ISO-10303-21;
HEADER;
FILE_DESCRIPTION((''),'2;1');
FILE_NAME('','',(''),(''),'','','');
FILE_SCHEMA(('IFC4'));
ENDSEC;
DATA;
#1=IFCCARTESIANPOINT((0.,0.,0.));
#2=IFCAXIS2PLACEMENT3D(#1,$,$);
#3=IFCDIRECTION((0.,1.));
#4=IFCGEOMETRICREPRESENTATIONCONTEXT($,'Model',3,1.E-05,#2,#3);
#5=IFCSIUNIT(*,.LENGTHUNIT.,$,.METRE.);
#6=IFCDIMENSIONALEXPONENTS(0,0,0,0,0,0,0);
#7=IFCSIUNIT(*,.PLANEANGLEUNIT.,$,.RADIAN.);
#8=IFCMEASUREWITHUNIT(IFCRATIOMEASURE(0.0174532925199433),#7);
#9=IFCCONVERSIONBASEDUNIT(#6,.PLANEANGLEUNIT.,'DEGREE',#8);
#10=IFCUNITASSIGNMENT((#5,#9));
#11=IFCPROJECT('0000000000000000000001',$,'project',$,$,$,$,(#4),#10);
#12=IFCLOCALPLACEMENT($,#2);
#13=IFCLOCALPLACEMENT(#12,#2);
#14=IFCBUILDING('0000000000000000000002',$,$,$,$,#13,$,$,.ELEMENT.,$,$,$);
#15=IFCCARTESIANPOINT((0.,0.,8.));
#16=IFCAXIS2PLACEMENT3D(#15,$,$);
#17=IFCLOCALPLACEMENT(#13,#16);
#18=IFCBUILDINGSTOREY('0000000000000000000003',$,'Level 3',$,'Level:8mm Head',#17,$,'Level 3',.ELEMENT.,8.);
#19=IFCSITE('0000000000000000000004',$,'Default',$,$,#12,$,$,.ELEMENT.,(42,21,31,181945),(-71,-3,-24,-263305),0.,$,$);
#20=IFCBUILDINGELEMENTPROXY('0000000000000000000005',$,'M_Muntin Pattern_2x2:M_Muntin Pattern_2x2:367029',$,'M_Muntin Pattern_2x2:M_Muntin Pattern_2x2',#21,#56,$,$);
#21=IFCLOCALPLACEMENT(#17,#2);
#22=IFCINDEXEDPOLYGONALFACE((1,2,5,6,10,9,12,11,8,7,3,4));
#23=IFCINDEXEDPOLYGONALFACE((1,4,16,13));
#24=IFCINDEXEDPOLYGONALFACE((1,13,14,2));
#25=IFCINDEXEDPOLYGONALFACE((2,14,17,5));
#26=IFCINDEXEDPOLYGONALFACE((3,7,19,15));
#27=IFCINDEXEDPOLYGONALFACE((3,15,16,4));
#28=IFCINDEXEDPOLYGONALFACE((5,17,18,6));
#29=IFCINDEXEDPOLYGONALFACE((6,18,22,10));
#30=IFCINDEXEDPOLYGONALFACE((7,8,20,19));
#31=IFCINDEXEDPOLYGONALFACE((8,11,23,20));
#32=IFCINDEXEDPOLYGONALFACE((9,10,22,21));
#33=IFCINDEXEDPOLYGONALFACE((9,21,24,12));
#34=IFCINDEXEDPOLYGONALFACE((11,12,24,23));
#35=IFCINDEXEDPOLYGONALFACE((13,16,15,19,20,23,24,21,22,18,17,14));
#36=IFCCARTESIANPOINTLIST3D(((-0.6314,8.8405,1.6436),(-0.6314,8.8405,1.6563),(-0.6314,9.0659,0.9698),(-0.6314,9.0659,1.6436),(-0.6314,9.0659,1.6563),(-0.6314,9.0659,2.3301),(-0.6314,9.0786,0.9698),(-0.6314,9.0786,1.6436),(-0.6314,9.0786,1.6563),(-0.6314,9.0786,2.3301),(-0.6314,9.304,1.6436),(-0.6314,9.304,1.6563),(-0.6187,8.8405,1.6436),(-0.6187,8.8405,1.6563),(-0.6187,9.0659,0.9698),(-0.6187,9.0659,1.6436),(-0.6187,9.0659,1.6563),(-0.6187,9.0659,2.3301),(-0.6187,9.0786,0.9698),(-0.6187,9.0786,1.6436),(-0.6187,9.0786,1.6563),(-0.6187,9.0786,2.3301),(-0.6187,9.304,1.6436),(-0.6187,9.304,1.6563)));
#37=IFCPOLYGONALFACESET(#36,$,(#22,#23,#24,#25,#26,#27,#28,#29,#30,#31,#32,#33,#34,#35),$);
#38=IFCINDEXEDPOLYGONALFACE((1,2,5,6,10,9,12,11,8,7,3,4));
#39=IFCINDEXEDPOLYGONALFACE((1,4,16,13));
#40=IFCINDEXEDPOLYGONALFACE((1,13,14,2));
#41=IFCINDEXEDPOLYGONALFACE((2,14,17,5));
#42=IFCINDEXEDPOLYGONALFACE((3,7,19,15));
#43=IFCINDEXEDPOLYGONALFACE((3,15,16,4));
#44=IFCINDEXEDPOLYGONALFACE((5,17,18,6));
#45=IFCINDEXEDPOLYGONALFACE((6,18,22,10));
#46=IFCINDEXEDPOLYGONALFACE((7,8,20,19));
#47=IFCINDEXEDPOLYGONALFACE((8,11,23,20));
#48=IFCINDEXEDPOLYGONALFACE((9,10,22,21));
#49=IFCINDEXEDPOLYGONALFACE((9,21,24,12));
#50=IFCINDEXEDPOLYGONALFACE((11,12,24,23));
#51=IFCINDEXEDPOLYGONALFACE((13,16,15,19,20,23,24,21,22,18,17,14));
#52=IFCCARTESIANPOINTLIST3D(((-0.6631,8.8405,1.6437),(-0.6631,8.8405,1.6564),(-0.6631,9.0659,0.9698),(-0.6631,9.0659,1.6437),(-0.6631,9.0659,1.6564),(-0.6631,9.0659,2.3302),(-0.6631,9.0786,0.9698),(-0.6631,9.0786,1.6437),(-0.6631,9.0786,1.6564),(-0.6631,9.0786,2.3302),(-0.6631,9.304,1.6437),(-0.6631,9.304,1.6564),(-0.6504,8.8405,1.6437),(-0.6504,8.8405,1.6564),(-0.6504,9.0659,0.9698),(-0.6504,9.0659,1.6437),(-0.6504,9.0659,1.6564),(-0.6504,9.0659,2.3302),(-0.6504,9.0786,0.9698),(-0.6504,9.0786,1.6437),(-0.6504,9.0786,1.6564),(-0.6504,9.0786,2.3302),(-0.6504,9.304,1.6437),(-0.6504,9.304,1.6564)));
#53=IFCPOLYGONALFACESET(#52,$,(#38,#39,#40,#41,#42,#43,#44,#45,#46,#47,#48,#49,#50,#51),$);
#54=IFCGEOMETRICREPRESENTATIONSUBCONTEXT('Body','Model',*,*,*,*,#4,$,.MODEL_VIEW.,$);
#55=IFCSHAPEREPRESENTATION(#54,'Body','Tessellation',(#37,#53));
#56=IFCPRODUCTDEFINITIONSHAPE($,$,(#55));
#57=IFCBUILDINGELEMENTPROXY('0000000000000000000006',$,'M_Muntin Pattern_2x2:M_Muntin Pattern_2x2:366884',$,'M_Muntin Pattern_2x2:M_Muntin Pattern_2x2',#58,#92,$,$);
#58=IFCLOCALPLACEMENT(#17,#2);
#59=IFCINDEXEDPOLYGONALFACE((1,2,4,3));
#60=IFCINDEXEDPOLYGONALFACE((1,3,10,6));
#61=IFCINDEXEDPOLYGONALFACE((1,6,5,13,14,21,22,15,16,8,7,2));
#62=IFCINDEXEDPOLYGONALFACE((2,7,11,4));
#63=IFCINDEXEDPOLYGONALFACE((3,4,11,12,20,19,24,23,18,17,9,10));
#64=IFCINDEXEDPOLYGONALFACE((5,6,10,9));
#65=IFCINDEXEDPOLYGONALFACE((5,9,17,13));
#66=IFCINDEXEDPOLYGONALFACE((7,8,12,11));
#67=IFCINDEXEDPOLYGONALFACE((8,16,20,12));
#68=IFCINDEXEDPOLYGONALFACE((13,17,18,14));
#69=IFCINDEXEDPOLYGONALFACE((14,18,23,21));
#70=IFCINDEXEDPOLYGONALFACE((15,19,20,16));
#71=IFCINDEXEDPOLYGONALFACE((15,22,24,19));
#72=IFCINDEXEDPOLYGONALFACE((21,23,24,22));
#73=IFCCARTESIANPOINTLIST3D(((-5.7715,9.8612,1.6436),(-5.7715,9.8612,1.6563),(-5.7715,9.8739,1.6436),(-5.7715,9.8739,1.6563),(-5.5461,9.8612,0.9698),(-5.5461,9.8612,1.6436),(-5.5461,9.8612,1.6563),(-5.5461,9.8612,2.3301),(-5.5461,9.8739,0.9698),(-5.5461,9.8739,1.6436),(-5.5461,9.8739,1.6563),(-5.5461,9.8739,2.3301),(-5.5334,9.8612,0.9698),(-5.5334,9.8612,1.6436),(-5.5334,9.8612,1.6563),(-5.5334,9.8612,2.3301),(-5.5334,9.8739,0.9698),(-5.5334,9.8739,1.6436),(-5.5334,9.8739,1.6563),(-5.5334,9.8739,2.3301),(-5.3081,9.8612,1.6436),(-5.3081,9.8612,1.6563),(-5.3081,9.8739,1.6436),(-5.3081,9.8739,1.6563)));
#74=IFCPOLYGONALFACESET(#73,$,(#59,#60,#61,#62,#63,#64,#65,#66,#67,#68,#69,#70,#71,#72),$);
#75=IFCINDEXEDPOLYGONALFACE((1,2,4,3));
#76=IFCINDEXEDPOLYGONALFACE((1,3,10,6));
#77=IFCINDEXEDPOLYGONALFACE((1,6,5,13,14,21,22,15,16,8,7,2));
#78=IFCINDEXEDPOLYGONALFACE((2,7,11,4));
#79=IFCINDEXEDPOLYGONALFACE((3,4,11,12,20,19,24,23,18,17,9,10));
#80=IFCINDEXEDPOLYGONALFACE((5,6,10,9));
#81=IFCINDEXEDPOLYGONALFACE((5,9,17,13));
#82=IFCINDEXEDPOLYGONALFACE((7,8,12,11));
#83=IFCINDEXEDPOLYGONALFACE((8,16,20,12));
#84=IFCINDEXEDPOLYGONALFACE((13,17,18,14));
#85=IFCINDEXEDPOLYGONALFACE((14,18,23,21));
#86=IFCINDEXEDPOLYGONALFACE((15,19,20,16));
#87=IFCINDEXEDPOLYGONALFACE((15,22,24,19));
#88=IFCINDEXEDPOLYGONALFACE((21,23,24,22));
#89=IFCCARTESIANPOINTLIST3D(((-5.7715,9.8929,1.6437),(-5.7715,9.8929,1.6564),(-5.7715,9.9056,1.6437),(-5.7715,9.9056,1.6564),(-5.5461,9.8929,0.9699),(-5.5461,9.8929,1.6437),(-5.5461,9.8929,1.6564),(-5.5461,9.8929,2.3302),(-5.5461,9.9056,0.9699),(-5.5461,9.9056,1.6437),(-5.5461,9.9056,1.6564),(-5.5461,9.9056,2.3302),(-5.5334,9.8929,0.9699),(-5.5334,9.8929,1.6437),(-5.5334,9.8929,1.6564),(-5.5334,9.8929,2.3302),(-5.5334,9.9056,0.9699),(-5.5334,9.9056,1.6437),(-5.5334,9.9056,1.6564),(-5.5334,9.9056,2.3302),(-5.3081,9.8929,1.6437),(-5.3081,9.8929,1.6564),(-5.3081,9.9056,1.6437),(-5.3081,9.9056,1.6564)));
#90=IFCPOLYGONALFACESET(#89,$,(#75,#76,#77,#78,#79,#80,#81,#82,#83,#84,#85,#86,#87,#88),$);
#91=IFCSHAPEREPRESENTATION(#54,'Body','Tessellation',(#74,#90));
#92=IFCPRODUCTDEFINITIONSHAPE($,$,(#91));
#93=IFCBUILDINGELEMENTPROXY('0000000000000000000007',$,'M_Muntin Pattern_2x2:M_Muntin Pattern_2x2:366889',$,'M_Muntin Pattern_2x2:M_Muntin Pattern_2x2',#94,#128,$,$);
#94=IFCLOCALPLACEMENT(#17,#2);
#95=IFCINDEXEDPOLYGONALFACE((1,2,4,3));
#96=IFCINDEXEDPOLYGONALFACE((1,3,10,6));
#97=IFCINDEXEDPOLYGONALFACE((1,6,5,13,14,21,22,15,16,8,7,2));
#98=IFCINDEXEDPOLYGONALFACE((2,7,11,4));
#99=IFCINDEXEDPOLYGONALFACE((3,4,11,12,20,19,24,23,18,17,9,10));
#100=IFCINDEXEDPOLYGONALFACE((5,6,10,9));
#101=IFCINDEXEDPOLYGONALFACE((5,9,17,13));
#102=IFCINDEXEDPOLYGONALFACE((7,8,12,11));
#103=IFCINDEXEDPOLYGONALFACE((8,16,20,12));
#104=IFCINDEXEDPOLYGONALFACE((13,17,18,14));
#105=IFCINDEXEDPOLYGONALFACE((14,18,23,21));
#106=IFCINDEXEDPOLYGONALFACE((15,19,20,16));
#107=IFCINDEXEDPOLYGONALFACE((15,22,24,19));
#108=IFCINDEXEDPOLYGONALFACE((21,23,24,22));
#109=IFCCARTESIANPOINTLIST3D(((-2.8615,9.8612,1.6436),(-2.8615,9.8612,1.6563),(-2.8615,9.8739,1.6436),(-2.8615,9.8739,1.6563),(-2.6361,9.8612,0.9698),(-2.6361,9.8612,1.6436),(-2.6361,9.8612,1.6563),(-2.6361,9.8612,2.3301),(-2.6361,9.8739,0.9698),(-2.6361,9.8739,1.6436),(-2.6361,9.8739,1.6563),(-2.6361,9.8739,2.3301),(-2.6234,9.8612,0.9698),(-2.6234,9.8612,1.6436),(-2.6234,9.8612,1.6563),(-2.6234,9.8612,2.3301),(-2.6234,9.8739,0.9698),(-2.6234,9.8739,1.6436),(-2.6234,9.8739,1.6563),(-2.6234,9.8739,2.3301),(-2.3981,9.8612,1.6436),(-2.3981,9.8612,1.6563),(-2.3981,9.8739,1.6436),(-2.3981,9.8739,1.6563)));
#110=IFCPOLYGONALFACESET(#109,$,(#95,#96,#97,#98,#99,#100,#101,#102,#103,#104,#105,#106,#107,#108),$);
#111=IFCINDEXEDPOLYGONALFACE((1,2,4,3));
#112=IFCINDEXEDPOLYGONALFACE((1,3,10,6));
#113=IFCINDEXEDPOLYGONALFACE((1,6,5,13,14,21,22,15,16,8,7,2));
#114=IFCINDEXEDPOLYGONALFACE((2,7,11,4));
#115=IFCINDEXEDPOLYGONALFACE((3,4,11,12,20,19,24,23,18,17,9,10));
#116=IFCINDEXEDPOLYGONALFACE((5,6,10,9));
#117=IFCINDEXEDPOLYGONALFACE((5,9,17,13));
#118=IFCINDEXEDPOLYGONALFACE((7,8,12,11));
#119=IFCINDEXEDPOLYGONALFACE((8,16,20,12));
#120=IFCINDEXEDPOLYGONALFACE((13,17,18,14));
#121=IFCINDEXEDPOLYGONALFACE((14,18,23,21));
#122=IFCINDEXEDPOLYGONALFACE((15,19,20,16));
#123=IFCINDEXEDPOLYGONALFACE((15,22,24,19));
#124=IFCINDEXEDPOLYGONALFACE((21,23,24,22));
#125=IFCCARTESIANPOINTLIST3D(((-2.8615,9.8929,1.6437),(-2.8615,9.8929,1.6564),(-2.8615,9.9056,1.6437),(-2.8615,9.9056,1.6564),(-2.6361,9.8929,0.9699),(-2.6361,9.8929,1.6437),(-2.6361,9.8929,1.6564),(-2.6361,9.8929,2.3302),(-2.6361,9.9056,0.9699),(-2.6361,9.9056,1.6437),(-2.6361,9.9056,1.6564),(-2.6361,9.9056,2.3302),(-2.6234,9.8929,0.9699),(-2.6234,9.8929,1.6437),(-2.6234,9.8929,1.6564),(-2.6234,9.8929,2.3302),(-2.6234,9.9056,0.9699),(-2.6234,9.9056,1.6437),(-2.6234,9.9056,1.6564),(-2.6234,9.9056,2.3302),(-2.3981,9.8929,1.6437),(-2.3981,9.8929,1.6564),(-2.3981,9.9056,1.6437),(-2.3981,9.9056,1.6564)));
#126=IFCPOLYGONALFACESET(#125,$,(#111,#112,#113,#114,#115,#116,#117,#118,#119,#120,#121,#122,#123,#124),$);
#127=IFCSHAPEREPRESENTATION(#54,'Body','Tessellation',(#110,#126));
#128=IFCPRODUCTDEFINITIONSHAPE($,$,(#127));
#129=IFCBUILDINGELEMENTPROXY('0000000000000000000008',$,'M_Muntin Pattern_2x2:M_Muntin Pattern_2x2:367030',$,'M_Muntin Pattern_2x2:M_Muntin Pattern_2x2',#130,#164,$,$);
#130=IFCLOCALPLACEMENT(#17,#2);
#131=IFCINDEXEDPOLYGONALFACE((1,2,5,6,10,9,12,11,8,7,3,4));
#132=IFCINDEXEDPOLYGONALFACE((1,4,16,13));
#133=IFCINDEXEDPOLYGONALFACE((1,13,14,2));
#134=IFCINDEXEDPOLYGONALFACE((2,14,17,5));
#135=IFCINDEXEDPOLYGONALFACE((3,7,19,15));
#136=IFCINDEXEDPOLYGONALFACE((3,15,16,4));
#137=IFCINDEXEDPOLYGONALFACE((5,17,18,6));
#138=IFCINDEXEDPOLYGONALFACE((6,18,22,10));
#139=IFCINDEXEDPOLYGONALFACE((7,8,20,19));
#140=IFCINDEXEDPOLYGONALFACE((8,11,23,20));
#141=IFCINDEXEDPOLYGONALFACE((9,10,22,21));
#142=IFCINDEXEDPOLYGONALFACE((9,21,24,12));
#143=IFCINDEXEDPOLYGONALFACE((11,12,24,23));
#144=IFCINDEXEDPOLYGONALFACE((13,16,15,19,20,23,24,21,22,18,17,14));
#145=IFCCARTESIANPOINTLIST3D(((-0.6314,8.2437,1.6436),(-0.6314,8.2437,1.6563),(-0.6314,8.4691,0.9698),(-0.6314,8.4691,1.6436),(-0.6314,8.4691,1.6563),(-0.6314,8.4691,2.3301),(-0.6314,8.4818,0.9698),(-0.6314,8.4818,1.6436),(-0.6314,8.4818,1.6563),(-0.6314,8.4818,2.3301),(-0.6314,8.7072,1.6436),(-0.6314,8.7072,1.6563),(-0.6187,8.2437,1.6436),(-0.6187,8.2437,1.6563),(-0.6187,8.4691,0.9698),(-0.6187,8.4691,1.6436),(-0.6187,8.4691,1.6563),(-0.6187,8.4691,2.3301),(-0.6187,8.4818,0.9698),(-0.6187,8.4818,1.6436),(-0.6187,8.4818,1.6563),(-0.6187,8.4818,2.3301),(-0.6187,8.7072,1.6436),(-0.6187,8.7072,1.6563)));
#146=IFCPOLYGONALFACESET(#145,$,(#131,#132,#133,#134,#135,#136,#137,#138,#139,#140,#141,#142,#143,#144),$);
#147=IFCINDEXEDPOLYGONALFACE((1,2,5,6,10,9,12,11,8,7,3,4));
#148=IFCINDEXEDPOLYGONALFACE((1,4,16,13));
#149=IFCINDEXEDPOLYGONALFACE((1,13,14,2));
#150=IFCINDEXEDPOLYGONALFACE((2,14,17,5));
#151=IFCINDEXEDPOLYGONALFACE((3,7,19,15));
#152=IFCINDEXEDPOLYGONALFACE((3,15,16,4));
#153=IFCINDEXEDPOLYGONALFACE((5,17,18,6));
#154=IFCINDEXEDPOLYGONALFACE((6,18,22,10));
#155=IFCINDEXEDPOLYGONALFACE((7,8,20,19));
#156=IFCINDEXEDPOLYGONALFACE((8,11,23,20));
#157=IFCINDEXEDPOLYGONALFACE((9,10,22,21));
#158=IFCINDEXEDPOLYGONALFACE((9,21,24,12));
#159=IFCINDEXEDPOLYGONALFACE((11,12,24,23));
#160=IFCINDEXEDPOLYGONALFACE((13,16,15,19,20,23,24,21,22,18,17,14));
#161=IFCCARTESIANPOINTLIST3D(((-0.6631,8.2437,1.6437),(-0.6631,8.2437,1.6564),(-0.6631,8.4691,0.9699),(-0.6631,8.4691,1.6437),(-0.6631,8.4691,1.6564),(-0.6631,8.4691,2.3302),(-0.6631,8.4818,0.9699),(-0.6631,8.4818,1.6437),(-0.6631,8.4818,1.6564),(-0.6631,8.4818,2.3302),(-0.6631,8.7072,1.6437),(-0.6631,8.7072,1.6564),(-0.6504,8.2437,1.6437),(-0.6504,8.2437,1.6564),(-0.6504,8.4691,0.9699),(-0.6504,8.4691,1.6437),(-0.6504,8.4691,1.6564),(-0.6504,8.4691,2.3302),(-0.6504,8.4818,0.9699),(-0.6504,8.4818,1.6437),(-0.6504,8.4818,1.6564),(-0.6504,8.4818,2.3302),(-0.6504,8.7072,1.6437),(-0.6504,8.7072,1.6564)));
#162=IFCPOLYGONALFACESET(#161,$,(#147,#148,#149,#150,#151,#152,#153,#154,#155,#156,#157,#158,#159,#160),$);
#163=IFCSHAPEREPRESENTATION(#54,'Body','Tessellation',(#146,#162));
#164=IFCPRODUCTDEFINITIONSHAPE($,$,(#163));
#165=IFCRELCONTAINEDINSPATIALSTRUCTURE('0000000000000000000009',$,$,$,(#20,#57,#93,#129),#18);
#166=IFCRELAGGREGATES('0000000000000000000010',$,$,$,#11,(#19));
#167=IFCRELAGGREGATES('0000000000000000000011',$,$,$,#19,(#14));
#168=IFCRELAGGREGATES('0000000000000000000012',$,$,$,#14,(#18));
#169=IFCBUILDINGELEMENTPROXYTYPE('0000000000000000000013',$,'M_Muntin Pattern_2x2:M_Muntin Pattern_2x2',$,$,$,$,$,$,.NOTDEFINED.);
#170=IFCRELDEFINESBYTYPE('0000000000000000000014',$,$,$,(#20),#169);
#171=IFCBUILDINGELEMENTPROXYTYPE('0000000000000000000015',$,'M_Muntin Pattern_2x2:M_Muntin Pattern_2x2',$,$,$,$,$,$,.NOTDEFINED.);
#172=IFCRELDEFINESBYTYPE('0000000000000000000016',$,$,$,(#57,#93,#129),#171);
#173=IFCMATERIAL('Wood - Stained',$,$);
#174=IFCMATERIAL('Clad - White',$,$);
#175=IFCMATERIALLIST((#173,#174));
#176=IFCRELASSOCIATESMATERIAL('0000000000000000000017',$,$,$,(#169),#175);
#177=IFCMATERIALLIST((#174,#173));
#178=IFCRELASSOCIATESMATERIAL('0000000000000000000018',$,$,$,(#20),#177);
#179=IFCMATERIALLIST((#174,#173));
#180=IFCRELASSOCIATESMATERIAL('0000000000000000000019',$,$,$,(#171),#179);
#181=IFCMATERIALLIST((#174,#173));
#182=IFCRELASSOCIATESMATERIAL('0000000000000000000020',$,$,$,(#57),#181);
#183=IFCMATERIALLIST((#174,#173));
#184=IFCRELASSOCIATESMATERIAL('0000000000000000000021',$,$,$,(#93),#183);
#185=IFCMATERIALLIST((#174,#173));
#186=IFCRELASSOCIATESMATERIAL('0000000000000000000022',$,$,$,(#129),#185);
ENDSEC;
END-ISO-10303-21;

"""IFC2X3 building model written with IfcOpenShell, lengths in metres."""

from ifc_helpers import new_model, entity, si_unit, converted_unit, direction, frame, origin, place, context, subcontext, project, spatial, polyline, outline, extrude, source, transform, mapped, material, material_list, type_object, type_shapes, element, save


model = new_model("IFC2X3")

# Units and contexts
model_context = context("Model", 3, precision=1e-05, world=origin(), true_north=direction((0.0, 1.0)))
body_context = subcontext(model_context, "Body", "Model", "MODEL_VIEW")
ifc_project = project(units=[si_unit("LENGTHUNIT", "METRE"), converted_unit("PLANEANGLEUNIT", "DEGREE", entity("IfcRatioMeasure", 0.0174532925199433), si_unit("PLANEANGLEUNIT", "RADIAN"), dimensions=[0, 0, 0, 0, 0, 0, 0])], contexts=[model_context])

# Site, building, storey
site_placement = place(None, origin())
site = spatial("IfcSite", under=ifc_project, at=site_placement, Name="Default", CompositionType="ELEMENT", RefLatitude=(42, 21, 31, 181945), RefLongitude=(-71, -3, -24, -263305), RefElevation=0.0)
building_placement = place(site_placement, origin())
building = spatial("IfcBuilding", under=site, at=building_placement, CompositionType="ELEMENT")
storey_placement = place(building_placement, frame((0.0, 0.0, 8.0)))
storey = spatial("IfcBuildingStorey", under=building, at=storey_placement, Name="Level 3", ObjectType="Level:8mm Head", LongName="Level 3", CompositionType="ELEMENT", Elevation=8.0)

# Building element proxies
ifc_material_1 = material(Name="Clad - White")
ifc_material_2 = material(Name="Wood - Stained")
ifc_material_list_1 = material_list([ifc_material_2, ifc_material_1])
building_element_proxy_type_1 = type_object("IfcBuildingElementProxyType", Name="M_Muntin Pattern_2x2:M_Muntin Pattern_2x2", PredefinedType="NOTDEFINED", material=ifc_material_list_1)
shared_shape_1 = source(origin(), body_context, "Body", "SweptSolid", [
    extrude(outline(polyline([(0.0064, -0.0064), (0.6801, -0.0064), (0.6801, 0.0063), (0.0064, 0.0063), (0.0064, 0.2317), (-0.0063, 0.2317), (-0.0063, 0.0063), (-0.6802, 0.0063), (-0.6802, -0.0064), (-0.0063, -0.0064), (-0.0063, -0.2317), (0.0064, -0.2317), (0.0064, -0.0064)])), frame((0.0, 0.0095, 0.6801), z_axis=(0.0, 1.0, 0.0), x_axis=(0.0, 0.0, 1.0)), (0.0, 0.0, 1.0), 0.0127),
    extrude(outline(polyline([(0.0064, -0.0064), (0.6802, -0.0064), (0.6802, 0.0063), (0.0064, 0.0063), (0.0064, 0.2317), (-0.0063, 0.2317), (-0.0063, 0.0063), (-0.6802, 0.0063), (-0.6802, -0.0064), (-0.0063, -0.0064), (-0.0063, -0.2317), (0.0064, -0.2317), (0.0064, -0.0064)])), frame((0.0, -0.0222, 0.6802), z_axis=(0.0, 1.0, 0.0), x_axis=(0.0, 0.0, 1.0)), (0.0, 0.0, 1.0), 0.0127),
])
type_shapes(building_element_proxy_type_1, [shared_shape_1])
ifc_material_list_2 = material_list([ifc_material_1, ifc_material_2])
proxy_1_placement = place(storey_placement, frame((-0.6409, 9.0723, 0.9698), z_axis=(0.0, 0.0, 1.0), x_axis=(0.0, -1.0, 0.0)))
element("IfcBuildingElementProxy", 1, at=proxy_1_placement, inside=storey, type_object=building_element_proxy_type_1, material=ifc_material_list_2, Name="M_Muntin Pattern_2x2:M_Muntin Pattern_2x2:367029", ObjectType="M_Muntin Pattern_2x2:M_Muntin Pattern_2x2", context=body_context, shape_type="MappedRepresentation", body=[
    mapped(shared_shape_1, transform((0.0, 0.0, 0.0), scale=1.0)),
])
ifc_material_list_3 = material_list([ifc_material_1, ifc_material_2])
ifc_material_list_4 = material_list([ifc_material_1, ifc_material_2])
building_element_proxy_type_2 = type_object("IfcBuildingElementProxyType", Name="M_Muntin Pattern_2x2:M_Muntin Pattern_2x2", PredefinedType="NOTDEFINED", material=ifc_material_list_4)
shared_shape_2 = source(origin(), body_context, "Body", "SweptSolid", [
    extrude(outline(polyline([(0.0064, -0.0064), (0.6801, -0.0064), (0.6801, 0.0063), (0.0064, 0.0063), (0.0064, 0.2317), (-0.0063, 0.2317), (-0.0063, 0.0063), (-0.6802, 0.0063), (-0.6802, -0.0064), (-0.0063, -0.0064), (-0.0063, -0.2317), (0.0064, -0.2317), (0.0064, -0.0064)])), frame((0.0, -0.0222, 0.6801), z_axis=(0.0, 1.0, 0.0), x_axis=(0.0, 0.0, 1.0)), (0.0, 0.0, 1.0), 0.0127),
    extrude(outline(polyline([(0.0064, -0.0064), (0.6802, -0.0064), (0.6802, 0.0063), (0.0064, 0.0063), (0.0064, 0.2317), (-0.0063, 0.2317), (-0.0063, 0.0063), (-0.6802, 0.0063), (-0.6802, -0.0064), (-0.0063, -0.0064), (-0.0063, -0.2317), (0.0064, -0.2317), (0.0064, -0.0064)])), frame((0.0, 0.0095, 0.6802), z_axis=(0.0, 1.0, 0.0), x_axis=(0.0, 0.0, 1.0)), (0.0, 0.0, 1.0), 0.0127),
])
type_shapes(building_element_proxy_type_2, [shared_shape_2])
proxy_2_placement = place(storey_placement, frame((-5.5398, 9.8834, 0.9699)))
element("IfcBuildingElementProxy", 2, at=proxy_2_placement, inside=storey, type_object=building_element_proxy_type_2, material=ifc_material_list_3, Name="M_Muntin Pattern_2x2:M_Muntin Pattern_2x2:366884", ObjectType="M_Muntin Pattern_2x2:M_Muntin Pattern_2x2", context=body_context, shape_type="MappedRepresentation", body=[
    mapped(shared_shape_2, transform((0.0, 0.0, 0.0), scale=1.0)),
])
ifc_material_list_5 = material_list([ifc_material_1, ifc_material_2])
proxy_3_placement = place(storey_placement, frame((-2.6298, 9.8834, 0.9699)))
element("IfcBuildingElementProxy", 3, at=proxy_3_placement, inside=storey, type_object=building_element_proxy_type_2, material=ifc_material_list_5, Name="M_Muntin Pattern_2x2:M_Muntin Pattern_2x2:366889", ObjectType="M_Muntin Pattern_2x2:M_Muntin Pattern_2x2", context=body_context, shape_type="MappedRepresentation", body=[
    mapped(shared_shape_2, transform((0.0, 0.0, 0.0), scale=1.0)),
])
ifc_material_list_6 = material_list([ifc_material_1, ifc_material_2])
proxy_4_placement = place(storey_placement, frame((-0.6409, 8.4754, 0.9699), z_axis=(0.0, 0.0, 1.0), x_axis=(0.0, 1.0, 0.0)))
element("IfcBuildingElementProxy", 4, at=proxy_4_placement, inside=storey, type_object=building_element_proxy_type_2, material=ifc_material_list_6, Name="M_Muntin Pattern_2x2:M_Muntin Pattern_2x2:367030", ObjectType="M_Muntin Pattern_2x2:M_Muntin Pattern_2x2", context=body_context, shape_type="MappedRepresentation", body=[
    mapped(shared_shape_2, transform((0.0, 0.0, 0.0), scale=1.0)),
])

save(model, "model.ifc")
